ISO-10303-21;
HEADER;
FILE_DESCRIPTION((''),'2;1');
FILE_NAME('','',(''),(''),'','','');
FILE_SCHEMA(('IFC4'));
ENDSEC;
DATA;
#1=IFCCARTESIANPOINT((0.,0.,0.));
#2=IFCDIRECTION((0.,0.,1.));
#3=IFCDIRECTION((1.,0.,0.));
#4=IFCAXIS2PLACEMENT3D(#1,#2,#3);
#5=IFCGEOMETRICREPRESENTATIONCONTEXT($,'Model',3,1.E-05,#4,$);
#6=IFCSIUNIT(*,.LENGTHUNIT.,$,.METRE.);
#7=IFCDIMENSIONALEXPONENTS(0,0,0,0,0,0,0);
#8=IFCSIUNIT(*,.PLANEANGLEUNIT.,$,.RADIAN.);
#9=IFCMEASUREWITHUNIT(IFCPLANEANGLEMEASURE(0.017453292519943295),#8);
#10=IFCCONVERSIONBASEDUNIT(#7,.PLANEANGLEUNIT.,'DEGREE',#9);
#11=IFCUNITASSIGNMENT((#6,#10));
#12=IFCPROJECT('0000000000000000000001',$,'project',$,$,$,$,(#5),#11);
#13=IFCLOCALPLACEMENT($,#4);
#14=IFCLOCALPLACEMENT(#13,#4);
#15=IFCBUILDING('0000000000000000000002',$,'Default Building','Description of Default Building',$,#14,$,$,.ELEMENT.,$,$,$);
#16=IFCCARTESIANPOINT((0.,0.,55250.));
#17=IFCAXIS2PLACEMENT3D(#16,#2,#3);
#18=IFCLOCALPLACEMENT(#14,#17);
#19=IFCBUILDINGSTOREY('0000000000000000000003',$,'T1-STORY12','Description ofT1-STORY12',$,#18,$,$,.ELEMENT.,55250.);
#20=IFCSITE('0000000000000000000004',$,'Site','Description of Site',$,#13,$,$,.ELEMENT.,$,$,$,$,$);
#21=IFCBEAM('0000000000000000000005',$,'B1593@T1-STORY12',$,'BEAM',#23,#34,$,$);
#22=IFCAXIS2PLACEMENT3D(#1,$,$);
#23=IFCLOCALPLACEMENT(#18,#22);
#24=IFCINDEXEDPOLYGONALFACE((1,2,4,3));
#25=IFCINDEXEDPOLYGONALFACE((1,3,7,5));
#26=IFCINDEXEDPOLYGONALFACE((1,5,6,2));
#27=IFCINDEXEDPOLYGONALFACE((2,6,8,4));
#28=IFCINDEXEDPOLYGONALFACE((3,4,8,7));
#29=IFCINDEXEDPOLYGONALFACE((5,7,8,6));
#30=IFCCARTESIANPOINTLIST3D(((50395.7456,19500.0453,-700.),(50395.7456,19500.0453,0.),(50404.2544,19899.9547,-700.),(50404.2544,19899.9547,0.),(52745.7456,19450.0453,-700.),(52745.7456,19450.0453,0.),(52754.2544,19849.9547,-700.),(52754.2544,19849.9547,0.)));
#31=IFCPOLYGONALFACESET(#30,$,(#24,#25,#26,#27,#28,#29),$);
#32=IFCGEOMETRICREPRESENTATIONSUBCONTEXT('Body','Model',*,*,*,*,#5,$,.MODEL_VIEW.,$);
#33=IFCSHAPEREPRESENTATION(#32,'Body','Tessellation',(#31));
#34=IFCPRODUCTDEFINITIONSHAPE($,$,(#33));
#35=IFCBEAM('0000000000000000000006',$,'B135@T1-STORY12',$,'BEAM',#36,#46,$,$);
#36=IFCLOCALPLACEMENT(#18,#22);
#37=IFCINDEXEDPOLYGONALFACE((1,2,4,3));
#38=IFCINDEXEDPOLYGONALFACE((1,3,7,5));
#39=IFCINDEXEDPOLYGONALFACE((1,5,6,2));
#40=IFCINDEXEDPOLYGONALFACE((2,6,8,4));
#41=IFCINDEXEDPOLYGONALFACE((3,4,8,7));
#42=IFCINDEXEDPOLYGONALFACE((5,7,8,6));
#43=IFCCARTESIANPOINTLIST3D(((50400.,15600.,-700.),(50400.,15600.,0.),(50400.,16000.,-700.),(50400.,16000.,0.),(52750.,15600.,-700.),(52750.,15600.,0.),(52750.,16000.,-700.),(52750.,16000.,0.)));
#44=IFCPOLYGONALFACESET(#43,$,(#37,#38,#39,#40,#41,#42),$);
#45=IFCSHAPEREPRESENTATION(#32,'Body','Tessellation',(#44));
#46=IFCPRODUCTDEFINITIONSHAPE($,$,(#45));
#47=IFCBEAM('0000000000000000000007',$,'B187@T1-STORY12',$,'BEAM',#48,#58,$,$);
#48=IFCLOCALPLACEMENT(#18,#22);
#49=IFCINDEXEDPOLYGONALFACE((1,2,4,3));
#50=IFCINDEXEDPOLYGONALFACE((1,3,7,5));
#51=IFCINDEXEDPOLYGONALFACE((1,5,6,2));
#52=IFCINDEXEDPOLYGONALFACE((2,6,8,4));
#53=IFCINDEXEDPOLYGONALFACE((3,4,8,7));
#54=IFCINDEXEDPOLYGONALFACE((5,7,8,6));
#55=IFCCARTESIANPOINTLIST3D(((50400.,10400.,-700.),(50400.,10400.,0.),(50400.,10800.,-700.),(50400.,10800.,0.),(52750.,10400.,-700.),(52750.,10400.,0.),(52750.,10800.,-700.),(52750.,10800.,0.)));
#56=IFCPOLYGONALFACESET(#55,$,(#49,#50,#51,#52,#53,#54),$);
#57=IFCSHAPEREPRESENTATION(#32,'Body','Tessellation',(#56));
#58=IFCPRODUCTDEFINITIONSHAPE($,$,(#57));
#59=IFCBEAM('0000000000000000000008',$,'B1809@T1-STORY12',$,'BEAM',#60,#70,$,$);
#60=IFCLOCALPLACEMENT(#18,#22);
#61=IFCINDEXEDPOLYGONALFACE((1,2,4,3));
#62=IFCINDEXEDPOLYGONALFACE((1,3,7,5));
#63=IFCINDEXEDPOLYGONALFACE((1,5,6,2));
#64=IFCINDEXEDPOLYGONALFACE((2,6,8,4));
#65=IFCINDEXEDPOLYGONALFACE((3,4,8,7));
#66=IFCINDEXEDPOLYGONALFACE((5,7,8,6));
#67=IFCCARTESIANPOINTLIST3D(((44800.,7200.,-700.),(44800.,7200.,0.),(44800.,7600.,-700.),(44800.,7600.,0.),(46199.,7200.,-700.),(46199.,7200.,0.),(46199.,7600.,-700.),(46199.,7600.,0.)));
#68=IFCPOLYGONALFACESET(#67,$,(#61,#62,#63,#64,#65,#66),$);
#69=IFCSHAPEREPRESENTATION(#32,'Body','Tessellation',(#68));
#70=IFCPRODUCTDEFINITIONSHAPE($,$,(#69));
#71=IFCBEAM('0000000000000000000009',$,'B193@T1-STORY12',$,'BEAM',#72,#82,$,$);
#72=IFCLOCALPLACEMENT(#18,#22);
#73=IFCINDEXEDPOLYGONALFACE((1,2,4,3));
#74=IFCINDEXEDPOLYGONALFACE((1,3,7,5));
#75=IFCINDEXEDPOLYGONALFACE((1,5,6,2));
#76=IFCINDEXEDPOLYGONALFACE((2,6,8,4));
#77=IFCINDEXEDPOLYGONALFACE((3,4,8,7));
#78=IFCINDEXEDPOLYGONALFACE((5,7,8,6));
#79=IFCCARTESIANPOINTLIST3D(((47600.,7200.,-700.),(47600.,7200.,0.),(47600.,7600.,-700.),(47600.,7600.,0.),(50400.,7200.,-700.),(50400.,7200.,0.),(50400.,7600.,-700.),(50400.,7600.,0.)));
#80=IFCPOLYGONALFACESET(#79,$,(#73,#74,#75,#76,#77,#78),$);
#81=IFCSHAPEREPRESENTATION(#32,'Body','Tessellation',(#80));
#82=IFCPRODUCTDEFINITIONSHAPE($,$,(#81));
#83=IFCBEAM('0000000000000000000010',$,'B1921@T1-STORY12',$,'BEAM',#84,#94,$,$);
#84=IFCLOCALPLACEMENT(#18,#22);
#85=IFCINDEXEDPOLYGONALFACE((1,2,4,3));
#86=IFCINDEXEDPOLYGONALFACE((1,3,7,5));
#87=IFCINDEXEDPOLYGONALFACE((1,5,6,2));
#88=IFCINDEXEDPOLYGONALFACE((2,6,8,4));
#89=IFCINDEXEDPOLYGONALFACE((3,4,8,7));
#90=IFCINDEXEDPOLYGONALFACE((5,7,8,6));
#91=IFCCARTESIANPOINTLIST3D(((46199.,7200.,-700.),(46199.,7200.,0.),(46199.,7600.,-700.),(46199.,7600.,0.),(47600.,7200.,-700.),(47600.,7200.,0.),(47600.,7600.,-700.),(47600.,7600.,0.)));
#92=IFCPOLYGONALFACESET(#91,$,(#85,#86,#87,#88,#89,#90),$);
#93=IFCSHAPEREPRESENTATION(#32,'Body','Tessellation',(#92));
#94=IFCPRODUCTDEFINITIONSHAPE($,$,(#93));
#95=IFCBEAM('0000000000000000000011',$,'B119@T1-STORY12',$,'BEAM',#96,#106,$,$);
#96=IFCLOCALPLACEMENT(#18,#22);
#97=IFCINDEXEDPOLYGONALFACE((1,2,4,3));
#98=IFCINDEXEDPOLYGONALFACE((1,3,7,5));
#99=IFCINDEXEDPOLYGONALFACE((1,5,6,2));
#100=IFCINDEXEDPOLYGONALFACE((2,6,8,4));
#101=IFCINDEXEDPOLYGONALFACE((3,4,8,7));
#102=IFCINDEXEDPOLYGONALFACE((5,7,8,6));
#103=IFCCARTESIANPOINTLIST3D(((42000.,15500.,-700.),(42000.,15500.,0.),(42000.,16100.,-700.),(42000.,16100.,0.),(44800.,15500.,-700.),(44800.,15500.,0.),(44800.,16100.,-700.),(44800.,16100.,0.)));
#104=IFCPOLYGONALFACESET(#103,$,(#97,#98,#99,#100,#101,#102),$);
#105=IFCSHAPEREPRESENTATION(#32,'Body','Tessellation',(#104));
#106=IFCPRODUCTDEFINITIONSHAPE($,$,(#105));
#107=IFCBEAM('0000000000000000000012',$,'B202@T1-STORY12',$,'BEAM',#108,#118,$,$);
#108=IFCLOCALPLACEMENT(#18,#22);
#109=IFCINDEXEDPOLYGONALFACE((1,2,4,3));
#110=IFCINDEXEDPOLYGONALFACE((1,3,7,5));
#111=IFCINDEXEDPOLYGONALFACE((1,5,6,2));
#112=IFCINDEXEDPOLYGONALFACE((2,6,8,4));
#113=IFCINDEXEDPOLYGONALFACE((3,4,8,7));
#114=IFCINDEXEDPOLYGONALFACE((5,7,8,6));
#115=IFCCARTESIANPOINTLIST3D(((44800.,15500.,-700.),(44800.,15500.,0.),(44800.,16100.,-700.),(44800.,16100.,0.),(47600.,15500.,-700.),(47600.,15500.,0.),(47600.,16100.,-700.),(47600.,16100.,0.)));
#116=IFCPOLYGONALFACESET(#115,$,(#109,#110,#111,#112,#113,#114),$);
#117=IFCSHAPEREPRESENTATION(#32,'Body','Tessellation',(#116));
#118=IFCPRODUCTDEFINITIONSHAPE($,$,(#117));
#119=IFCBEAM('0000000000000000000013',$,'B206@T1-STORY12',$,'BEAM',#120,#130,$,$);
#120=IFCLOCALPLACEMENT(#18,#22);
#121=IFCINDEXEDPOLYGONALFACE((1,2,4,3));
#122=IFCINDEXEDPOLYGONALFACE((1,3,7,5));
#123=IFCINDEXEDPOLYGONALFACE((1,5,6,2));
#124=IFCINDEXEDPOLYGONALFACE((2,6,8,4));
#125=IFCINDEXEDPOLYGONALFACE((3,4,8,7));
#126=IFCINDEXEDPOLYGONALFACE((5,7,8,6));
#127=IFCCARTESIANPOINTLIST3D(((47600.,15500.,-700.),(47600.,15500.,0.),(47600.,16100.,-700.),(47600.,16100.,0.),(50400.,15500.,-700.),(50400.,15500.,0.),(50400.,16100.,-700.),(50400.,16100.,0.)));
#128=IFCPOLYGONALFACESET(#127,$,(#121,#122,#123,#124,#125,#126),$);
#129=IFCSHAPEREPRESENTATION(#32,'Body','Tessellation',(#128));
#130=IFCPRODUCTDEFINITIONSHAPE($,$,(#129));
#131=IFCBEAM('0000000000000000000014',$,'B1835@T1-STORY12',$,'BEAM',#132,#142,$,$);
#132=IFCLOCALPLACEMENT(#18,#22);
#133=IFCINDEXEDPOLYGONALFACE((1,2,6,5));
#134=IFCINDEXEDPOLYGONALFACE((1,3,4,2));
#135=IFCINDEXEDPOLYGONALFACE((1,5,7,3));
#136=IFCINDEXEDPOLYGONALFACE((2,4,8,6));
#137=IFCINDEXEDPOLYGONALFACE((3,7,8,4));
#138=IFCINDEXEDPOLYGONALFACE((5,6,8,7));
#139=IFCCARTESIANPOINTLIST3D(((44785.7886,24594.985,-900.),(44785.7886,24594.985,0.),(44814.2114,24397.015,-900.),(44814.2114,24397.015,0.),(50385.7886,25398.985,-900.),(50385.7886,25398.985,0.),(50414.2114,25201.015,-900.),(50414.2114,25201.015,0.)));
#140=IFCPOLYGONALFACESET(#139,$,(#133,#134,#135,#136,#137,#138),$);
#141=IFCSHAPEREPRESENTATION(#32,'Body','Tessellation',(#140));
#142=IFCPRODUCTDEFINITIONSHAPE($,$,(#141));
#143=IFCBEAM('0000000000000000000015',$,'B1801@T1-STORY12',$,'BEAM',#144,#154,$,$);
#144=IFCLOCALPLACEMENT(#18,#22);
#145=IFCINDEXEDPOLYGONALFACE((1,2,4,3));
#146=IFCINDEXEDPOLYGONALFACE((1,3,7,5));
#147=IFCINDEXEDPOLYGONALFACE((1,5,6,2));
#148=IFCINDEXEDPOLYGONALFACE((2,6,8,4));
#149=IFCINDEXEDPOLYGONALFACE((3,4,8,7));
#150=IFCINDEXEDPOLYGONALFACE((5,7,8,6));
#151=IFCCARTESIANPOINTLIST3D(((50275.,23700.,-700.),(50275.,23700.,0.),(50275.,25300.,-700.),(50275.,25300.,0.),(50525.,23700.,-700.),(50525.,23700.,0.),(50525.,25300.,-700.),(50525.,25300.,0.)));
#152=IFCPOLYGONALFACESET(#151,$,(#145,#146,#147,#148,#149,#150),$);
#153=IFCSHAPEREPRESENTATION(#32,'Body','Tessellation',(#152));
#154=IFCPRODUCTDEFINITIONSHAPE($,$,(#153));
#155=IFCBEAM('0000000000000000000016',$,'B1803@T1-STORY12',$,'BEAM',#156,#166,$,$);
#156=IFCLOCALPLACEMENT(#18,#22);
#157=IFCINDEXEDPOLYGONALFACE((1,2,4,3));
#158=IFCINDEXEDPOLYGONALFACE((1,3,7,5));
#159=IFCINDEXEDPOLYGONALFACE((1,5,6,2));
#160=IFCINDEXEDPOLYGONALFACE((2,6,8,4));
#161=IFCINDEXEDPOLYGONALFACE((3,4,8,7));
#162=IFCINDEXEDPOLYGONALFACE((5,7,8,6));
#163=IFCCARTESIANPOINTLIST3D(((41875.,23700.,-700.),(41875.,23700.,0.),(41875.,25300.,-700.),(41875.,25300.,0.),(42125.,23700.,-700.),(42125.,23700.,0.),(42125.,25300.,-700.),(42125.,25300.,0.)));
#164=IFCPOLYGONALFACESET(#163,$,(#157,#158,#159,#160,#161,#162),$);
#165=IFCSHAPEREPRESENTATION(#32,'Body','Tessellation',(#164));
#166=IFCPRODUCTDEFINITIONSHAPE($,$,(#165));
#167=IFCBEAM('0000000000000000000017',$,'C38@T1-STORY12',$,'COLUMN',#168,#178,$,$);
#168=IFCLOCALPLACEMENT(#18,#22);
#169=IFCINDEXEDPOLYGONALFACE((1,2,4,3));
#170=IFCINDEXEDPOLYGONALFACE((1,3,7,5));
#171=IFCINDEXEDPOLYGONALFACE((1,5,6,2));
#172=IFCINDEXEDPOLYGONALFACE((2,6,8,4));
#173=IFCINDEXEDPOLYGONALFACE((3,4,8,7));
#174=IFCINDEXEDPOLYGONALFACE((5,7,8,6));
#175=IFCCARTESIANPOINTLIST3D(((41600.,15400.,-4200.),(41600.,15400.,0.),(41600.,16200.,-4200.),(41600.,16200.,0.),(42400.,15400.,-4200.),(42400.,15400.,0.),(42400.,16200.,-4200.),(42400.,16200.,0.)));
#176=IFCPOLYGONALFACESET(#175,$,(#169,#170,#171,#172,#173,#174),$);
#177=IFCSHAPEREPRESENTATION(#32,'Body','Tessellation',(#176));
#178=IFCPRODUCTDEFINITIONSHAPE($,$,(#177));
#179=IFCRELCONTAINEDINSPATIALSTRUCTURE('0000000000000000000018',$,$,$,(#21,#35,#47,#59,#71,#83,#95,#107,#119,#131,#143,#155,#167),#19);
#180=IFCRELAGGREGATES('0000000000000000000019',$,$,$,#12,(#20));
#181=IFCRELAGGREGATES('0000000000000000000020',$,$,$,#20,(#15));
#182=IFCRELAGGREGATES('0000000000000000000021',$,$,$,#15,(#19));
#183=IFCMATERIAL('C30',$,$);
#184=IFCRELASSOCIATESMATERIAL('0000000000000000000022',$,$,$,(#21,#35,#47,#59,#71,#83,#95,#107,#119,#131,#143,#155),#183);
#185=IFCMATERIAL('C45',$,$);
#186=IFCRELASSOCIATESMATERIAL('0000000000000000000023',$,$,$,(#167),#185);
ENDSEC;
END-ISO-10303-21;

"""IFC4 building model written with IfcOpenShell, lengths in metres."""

from ifc_helpers import new_model, entity, si_unit, converted_unit, frame, origin_with_axes, place, context, subcontext, project, spatial, rectangle, extrude, material, element, save


model = new_model("IFC4")

# Units and contexts
model_context = context("Model", 3, precision=1e-05, world=origin_with_axes())
body_context = subcontext(model_context, "Body", "Model", "MODEL_VIEW")
ifc_project = project(units=[si_unit("LENGTHUNIT", "METRE"), converted_unit("PLANEANGLEUNIT", "DEGREE", entity("IfcPlaneAngleMeasure", 0.017453292519943295), si_unit("PLANEANGLEUNIT", "RADIAN"), dimensions=[0, 0, 0, 0, 0, 0, 0])], contexts=[model_context])

# Site, building, storey
site_placement = place(None, origin_with_axes())
site = spatial("IfcSite", under=ifc_project, at=site_placement, Name="Site", Description="Description of Site", CompositionType="ELEMENT")
building_placement = place(site_placement, origin_with_axes())
building = spatial("IfcBuilding", under=site, at=building_placement, Name="Default Building", Description="Description of Default Building", CompositionType="ELEMENT")
storey_placement = place(building_placement, frame((0.0, 0.0, 55250.0), z_axis=(0.0, 0.0, 1.0), x_axis=(1.0, 0.0, 0.0)))
storey = spatial("IfcBuildingStorey", under=building, at=storey_placement, Name="T1-STORY12", Description="Description ofT1-STORY12", CompositionType="ELEMENT", Elevation=55250.0)

# Beams
ifc_material_1 = material(Name="C30")
beam_1_placement = place(storey_placement, frame((50400.0, 19700.0, -350.0), z_axis=(0.999774, -0.021272, 0.0), x_axis=(0.021272, 0.999774, 0.0)))
element("IfcBeam", 1, at=beam_1_placement, inside=storey, material=ifc_material_1, Name="B1593@T1-STORY12", ObjectType="BEAM", context=body_context, shape_type="SweptSolid", body=[
    extrude(rectangle(XDim=400.0, YDim=700.0), origin_with_axes(), (0.0, 0.0, 1.0), 2350.5319),
])
for number, where, z_axis, x_axis, name in (
    (2, (50400.0, 15800.0, -350.0), (1.0, 0.0, 0.0), (0.0, 1.0, 0.0), "B135@T1-STORY12"),
    (3, (50400.0, 10600.0, -350.0), (1.0, 0.0, 0.0), (0.0, 1.0, 0.0), "B187@T1-STORY12"),
):
    element("IfcBeam", number, at=place(storey_placement, frame(where, z_axis=z_axis, x_axis=x_axis)), inside=storey, material=ifc_material_1, Name=name, ObjectType="BEAM", context=body_context, shape_type="SweptSolid", body=[
        extrude(rectangle(XDim=400.0, YDim=700.0), origin_with_axes(), (0.0, 0.0, 1.0), 2350.0),
    ])
beam_2_placement = place(storey_placement, frame((44800.0, 7400.0, -350.0), z_axis=(1.0, 0.0, 0.0), x_axis=(0.0, 1.0, 0.0)))
element("IfcBeam", 4, at=beam_2_placement, inside=storey, material=ifc_material_1, Name="B1809@T1-STORY12", ObjectType="BEAM", context=body_context, shape_type="SweptSolid", body=[
    extrude(rectangle(XDim=400.0, YDim=700.0), origin_with_axes(), (0.0, 0.0, 1.0), 1399.0),
])
beam_3_placement = place(storey_placement, frame((47600.0, 7400.0, -350.0), z_axis=(1.0, 0.0, 0.0), x_axis=(0.0, 1.0, 0.0)))
element("IfcBeam", 5, at=beam_3_placement, inside=storey, material=ifc_material_1, Name="B193@T1-STORY12", ObjectType="BEAM", context=body_context, shape_type="SweptSolid", body=[
    extrude(rectangle(XDim=400.0, YDim=700.0), origin_with_axes(), (0.0, 0.0, 1.0), 2800.0),
])
beam_4_placement = place(storey_placement, frame((46199.0, 7400.0, -350.0), z_axis=(1.0, 0.0, 0.0), x_axis=(0.0, 1.0, 0.0)))
element("IfcBeam", 6, at=beam_4_placement, inside=storey, material=ifc_material_1, Name="B1921@T1-STORY12", ObjectType="BEAM", context=body_context, shape_type="SweptSolid", body=[
    extrude(rectangle(XDim=400.0, YDim=700.0), origin_with_axes(), (0.0, 0.0, 1.0), 1401.0),
])
for number, where, z_axis, x_axis, name in (
    (7, (42000.0, 15800.0, -350.0), (1.0, 0.0, 0.0), (0.0, 1.0, 0.0), "B119@T1-STORY12"),
    (8, (44800.0, 15800.0, -350.0), (1.0, 0.0, 0.0), (0.0, 1.0, 0.0), "B202@T1-STORY12"),
    (9, (47600.0, 15800.0, -350.0), (1.0, 0.0, 0.0), (0.0, 1.0, 0.0), "B206@T1-STORY12"),
):
    element("IfcBeam", number, at=place(storey_placement, frame(where, z_axis=z_axis, x_axis=x_axis)), inside=storey, material=ifc_material_1, Name=name, ObjectType="BEAM", context=body_context, shape_type="SweptSolid", body=[
        extrude(rectangle(XDim=600.0, YDim=700.0), origin_with_axes(), (0.0, 0.0, 1.0), 2800.0),
    ])
beam_5_placement = place(storey_placement, frame((44800.0, 24496.0, -450.0), z_axis=(0.98985, 0.142114, 0.0), x_axis=(-0.142114, 0.98985, 0.0)))
element("IfcBeam", 10, at=beam_5_placement, inside=storey, material=ifc_material_1, Name="B1835@T1-STORY12", ObjectType="BEAM", context=body_context, shape_type="SweptSolid", body=[
    extrude(rectangle(XDim=200.0, YDim=900.0), origin_with_axes(), (0.0, 0.0, 1.0), 5657.4213),
])
for number, where, z_axis, x_axis, name in (
    (11, (50400.0, 23700.0, -350.0), (0.0, 1.0, 0.0), (-1.0, 0.0, 0.0), "B1801@T1-STORY12"),
    (12, (42000.0, 23700.0, -350.0), (0.0, 1.0, 0.0), (-1.0, 0.0, 0.0), "B1803@T1-STORY12"),
):
    element("IfcBeam", number, at=place(storey_placement, frame(where, z_axis=z_axis, x_axis=x_axis)), inside=storey, material=ifc_material_1, Name=name, ObjectType="BEAM", context=body_context, shape_type="SweptSolid", body=[
        extrude(rectangle(XDim=250.0, YDim=700.0), origin_with_axes(), (0.0, 0.0, 1.0), 1600.0),
    ])
ifc_material_2 = material(Name="C45")
beam_6_placement = place(storey_placement, frame((42000.0, 15800.0, -4200.0), z_axis=(0.0, 0.0, 1.0), x_axis=(-1.0, 0.0, 0.0)))
element("IfcBeam", 13, at=beam_6_placement, inside=storey, material=ifc_material_2, Name="C38@T1-STORY12", ObjectType="COLUMN", context=body_context, shape_type="SweptSolid", body=[
    extrude(rectangle(XDim=800.0, YDim=800.0), origin_with_axes(), (0.0, 0.0, 1.0), 4200.0),
])

save(model, "model.ifc")
